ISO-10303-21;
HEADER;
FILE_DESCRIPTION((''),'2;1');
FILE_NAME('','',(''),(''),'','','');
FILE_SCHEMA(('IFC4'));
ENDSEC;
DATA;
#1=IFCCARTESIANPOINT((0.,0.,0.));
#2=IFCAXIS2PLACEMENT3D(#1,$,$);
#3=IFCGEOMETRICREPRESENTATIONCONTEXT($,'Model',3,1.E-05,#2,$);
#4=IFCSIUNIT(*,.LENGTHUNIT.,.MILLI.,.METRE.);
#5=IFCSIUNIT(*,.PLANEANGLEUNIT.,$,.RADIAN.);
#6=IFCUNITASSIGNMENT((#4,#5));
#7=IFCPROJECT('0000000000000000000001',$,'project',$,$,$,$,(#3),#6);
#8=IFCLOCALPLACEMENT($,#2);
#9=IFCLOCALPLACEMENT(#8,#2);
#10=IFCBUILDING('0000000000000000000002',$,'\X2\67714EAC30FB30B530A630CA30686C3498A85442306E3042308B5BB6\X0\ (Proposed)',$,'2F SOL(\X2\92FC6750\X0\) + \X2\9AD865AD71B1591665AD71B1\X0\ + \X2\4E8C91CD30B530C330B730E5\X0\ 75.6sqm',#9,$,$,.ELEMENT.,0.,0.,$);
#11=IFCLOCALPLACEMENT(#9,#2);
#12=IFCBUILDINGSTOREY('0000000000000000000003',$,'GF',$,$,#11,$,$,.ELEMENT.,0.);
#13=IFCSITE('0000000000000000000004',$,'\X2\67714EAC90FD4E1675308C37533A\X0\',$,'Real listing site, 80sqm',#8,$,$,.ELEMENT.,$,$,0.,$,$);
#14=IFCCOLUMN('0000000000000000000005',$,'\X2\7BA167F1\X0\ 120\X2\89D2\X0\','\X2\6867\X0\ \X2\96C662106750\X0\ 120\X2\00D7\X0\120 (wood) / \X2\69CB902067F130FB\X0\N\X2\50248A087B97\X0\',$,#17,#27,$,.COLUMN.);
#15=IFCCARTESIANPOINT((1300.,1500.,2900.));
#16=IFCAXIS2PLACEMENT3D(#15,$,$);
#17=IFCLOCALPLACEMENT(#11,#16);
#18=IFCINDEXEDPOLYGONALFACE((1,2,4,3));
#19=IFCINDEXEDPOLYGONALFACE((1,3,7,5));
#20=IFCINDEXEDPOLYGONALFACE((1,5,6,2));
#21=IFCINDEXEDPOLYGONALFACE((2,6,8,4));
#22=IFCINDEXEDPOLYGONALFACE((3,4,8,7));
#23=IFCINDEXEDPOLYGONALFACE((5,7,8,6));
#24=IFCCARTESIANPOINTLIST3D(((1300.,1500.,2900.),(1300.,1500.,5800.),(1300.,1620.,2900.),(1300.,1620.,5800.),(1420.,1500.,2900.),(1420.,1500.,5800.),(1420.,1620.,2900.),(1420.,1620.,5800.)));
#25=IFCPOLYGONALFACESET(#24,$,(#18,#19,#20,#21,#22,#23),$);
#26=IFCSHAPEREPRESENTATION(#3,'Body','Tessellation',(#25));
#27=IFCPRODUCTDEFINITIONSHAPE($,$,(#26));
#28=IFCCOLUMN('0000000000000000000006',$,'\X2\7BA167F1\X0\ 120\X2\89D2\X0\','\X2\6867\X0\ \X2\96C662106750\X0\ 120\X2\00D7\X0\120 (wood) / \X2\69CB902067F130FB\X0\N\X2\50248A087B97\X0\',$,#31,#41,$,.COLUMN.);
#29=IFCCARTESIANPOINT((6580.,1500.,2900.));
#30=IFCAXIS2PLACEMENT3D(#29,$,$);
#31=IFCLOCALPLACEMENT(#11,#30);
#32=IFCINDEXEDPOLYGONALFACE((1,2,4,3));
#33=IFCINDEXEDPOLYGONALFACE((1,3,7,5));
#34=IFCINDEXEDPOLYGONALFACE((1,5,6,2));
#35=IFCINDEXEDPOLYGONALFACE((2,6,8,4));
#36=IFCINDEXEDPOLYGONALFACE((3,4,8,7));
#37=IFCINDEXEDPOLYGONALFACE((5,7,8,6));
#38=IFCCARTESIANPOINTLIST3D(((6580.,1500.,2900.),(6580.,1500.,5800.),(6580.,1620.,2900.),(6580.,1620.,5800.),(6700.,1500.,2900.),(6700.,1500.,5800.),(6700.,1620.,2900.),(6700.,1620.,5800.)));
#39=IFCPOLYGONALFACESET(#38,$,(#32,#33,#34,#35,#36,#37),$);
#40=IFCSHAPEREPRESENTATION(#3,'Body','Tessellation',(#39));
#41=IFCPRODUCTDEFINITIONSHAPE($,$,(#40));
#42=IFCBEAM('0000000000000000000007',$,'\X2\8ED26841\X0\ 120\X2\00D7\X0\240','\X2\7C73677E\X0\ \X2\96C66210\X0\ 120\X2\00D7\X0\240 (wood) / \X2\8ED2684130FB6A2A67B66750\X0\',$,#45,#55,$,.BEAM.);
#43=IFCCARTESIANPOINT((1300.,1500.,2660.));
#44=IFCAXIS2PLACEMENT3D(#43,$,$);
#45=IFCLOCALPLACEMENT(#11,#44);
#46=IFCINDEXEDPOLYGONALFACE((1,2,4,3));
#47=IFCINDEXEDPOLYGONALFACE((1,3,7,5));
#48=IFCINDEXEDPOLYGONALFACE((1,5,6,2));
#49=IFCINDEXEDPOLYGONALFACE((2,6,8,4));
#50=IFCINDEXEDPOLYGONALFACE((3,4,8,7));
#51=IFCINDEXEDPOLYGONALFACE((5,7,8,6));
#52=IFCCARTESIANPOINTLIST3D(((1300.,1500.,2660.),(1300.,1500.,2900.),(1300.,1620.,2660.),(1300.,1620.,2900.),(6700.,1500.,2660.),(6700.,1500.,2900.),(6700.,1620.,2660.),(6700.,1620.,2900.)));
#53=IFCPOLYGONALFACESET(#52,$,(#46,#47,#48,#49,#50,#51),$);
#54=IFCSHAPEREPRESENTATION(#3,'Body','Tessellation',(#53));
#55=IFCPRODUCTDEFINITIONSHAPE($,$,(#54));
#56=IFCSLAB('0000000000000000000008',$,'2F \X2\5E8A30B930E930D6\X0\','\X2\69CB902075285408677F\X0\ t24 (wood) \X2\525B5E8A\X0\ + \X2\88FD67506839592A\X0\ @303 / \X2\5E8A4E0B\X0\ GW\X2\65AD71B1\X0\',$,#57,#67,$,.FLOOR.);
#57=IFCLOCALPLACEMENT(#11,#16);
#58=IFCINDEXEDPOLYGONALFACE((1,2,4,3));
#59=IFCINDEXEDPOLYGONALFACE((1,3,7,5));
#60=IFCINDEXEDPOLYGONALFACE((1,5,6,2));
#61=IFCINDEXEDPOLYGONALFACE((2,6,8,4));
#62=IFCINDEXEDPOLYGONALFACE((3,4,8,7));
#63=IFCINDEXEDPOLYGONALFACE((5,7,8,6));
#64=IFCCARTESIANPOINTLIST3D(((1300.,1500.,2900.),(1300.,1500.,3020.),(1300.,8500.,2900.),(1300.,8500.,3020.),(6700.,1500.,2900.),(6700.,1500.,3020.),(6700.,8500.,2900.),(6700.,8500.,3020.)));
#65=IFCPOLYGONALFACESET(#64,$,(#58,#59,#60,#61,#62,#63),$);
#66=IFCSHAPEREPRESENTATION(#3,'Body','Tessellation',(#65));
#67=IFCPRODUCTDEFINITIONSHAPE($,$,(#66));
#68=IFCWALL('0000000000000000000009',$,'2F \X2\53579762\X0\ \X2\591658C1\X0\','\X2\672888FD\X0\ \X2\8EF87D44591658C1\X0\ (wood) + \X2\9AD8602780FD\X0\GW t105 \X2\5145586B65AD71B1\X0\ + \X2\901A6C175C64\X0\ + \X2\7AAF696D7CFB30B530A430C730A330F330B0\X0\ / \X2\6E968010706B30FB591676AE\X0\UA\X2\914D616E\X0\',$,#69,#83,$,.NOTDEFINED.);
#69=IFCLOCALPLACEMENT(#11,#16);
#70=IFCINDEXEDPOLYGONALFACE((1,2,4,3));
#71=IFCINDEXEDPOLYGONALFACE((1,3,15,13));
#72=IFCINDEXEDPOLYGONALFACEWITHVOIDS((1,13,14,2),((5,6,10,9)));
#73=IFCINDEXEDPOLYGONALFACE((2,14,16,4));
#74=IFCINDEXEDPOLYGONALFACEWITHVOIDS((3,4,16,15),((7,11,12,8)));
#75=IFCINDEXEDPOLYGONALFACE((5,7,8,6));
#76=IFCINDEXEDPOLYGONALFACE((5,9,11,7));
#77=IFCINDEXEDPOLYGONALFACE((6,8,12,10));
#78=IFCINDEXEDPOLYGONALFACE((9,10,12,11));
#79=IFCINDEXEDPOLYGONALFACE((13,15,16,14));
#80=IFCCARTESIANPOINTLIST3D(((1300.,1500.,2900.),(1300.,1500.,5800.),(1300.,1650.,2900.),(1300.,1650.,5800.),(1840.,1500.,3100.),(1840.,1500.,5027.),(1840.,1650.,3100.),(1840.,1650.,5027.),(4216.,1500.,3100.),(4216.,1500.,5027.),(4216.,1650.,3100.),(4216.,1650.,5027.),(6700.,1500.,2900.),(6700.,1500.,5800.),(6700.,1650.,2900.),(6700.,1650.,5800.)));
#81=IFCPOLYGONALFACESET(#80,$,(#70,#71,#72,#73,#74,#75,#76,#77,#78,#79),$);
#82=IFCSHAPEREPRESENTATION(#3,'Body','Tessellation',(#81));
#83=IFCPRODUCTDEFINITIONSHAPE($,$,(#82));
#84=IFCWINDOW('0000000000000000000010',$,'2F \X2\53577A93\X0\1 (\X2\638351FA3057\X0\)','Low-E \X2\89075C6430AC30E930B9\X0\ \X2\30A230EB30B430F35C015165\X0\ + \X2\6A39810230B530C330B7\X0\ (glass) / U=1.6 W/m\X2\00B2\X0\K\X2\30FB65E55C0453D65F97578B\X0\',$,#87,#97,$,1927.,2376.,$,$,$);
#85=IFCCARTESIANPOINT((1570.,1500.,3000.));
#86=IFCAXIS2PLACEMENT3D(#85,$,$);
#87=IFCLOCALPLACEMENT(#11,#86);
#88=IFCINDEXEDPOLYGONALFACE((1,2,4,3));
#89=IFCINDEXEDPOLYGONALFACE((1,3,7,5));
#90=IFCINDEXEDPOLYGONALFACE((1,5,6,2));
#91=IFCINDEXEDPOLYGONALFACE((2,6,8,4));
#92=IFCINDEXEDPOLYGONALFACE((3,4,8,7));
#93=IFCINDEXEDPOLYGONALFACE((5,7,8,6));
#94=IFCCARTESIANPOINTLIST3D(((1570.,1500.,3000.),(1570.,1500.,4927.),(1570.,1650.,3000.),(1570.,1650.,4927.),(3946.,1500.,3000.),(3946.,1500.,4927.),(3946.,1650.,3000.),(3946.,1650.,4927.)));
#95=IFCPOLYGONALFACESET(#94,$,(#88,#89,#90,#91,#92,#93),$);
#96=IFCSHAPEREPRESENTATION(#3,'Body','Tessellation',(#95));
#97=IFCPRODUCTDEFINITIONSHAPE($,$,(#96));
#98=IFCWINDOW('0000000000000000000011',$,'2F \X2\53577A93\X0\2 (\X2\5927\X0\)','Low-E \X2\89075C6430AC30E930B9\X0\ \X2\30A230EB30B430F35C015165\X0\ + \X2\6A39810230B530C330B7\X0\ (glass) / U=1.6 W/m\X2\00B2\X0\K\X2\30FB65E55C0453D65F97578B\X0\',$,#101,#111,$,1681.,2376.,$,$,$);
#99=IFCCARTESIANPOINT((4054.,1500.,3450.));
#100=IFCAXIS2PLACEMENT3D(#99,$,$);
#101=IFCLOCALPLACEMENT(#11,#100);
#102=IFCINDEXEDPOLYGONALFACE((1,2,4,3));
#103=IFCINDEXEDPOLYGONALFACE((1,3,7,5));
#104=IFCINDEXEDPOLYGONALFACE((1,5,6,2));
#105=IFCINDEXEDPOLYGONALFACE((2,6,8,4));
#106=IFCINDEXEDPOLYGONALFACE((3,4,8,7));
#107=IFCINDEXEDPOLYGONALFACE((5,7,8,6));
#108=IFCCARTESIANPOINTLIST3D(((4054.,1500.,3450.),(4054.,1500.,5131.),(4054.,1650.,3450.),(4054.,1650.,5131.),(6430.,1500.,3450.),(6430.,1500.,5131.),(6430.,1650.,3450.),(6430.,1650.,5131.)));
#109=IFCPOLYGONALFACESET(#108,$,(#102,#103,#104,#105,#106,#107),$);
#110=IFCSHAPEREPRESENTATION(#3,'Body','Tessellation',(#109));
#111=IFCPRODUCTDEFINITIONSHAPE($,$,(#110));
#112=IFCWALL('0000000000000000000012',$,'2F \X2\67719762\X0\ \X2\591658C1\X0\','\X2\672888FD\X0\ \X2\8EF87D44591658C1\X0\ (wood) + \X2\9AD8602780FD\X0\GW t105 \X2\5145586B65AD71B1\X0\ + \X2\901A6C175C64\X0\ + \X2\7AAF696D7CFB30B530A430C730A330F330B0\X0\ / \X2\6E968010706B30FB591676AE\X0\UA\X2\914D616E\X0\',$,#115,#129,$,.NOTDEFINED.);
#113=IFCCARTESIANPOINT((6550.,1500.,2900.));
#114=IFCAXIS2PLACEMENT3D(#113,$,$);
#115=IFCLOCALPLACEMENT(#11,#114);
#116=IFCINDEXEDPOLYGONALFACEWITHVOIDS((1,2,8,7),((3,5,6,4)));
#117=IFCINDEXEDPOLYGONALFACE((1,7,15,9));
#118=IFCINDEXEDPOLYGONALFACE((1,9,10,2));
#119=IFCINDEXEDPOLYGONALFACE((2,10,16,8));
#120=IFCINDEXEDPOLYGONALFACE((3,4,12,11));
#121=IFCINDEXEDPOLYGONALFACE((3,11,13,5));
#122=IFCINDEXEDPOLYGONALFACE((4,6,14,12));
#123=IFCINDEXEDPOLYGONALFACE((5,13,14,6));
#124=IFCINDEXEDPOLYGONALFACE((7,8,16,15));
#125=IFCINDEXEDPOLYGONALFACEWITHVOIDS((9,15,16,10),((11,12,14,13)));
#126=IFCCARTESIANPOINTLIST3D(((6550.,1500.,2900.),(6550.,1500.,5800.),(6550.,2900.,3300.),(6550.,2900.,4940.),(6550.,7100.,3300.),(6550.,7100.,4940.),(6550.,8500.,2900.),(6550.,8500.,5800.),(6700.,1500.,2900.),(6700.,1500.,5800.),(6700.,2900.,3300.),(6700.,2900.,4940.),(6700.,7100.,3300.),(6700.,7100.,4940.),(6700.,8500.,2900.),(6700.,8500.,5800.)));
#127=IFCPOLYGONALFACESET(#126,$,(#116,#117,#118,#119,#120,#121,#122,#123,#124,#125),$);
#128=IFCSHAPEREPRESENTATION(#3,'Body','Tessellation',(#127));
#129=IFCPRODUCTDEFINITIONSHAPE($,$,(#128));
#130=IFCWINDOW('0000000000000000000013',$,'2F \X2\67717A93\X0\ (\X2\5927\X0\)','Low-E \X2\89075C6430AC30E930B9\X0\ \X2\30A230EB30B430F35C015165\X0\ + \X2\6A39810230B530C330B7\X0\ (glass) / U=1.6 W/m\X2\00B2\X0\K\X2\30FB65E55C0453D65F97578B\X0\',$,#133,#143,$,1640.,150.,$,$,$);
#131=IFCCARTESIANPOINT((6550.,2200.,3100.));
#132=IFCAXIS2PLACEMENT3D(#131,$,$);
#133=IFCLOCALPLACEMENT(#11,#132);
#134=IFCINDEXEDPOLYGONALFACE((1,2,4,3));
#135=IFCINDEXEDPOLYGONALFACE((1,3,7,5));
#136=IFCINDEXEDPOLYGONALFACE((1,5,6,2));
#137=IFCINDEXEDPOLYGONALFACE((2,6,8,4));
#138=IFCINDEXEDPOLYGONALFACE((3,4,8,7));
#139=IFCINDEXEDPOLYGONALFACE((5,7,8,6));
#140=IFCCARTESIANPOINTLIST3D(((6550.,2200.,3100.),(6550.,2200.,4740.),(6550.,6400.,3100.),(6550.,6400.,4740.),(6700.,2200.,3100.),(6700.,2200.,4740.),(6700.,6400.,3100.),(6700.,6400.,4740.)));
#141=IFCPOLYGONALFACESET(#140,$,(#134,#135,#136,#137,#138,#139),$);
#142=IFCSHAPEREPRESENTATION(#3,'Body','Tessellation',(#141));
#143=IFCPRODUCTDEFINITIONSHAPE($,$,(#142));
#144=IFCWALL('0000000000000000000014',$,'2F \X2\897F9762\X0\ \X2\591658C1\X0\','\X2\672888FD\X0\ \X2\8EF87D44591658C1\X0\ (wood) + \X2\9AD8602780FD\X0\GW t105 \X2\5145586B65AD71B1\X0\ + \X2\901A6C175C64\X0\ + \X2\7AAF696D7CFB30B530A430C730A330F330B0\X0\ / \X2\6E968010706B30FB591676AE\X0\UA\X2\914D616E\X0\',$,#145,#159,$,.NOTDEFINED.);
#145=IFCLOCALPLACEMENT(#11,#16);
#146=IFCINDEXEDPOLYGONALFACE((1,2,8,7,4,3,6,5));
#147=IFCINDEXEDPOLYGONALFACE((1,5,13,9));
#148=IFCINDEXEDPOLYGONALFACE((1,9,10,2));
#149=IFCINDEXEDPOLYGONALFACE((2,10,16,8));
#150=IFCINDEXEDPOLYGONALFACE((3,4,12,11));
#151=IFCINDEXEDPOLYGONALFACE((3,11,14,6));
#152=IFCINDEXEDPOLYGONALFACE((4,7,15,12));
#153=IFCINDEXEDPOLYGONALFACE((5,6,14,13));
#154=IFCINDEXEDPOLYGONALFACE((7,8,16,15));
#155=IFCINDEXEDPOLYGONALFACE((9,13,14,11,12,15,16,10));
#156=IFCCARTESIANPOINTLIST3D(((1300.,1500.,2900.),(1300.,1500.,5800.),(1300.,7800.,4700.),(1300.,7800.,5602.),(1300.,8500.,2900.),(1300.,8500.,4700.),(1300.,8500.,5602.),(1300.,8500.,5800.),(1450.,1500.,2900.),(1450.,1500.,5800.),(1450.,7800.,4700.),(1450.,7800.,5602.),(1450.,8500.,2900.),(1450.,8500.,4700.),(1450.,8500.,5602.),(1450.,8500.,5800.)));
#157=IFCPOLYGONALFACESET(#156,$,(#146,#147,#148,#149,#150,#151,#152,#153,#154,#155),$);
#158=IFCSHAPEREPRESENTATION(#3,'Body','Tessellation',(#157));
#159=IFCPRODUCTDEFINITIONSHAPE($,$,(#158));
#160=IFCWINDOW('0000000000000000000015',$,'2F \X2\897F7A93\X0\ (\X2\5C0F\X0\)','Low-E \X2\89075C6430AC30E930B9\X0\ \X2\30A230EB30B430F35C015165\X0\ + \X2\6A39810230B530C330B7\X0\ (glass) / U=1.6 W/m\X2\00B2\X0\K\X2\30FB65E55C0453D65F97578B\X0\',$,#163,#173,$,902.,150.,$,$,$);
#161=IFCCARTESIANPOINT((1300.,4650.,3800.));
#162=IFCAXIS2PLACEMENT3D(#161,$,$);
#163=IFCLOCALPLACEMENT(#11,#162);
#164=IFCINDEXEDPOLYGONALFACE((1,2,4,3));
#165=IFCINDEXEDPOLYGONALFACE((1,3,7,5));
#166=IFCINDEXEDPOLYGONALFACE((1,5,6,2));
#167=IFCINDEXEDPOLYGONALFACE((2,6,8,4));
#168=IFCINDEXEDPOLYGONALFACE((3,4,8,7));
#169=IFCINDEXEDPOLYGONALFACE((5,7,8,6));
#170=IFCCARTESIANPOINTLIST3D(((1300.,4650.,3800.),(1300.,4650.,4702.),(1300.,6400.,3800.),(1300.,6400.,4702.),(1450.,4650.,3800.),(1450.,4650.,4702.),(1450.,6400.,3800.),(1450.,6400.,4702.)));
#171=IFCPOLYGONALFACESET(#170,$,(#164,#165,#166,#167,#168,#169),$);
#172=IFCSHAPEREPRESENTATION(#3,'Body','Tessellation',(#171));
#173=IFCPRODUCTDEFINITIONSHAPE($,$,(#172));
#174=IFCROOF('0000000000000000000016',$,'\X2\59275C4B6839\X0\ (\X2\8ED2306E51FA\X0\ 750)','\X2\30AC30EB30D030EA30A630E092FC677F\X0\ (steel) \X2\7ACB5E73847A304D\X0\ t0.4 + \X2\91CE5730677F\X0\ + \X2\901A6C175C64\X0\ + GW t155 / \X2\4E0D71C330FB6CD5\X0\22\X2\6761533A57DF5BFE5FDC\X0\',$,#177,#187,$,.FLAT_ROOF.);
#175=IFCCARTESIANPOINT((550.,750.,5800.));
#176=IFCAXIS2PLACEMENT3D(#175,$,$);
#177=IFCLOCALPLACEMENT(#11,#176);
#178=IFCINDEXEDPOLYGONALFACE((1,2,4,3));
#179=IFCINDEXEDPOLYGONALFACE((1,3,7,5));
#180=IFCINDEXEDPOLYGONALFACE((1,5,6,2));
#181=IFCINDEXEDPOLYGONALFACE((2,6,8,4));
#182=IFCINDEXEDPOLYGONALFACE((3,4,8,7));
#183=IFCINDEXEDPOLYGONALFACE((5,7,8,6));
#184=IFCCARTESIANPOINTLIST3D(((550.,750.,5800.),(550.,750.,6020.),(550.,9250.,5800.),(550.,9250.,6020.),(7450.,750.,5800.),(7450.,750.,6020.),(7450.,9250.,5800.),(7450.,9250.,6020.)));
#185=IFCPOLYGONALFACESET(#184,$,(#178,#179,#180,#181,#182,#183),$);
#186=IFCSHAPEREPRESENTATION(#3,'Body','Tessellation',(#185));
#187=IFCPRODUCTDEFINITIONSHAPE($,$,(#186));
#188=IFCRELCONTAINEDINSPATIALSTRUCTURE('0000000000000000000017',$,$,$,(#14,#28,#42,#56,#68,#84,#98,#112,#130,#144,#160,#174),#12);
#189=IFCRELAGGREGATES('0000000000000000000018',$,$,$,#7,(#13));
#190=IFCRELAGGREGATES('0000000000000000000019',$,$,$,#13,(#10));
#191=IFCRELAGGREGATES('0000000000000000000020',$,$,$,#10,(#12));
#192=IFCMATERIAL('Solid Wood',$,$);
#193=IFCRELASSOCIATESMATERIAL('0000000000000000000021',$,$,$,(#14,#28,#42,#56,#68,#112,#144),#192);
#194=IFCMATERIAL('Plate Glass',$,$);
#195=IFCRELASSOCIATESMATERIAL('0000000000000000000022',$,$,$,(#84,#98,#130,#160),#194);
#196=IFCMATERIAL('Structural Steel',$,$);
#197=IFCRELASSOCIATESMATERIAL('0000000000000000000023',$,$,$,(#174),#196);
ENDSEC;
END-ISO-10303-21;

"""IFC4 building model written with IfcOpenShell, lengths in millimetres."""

from ifc_helpers import new_model, si_unit, frame, frame_2d, origin, place, context, project, spatial, rectangle, extrude, material, element, fill, save


model = new_model("IFC4")

# Units and contexts
model_context = context("Model", 3, precision=1e-05, world=origin())
ifc_project = project(units=[si_unit("LENGTHUNIT", "METRE", prefix="MILLI"), si_unit("PLANEANGLEUNIT", "RADIAN")], contexts=[model_context])

# Site, building, storey
site_placement = place(None, origin())
site = spatial("IfcSite", under=ifc_project, at=site_placement, Name="東京都世田谷区", ObjectType="Real listing site, 80sqm", CompositionType="ELEMENT", RefElevation=0.0)
building_placement = place(site_placement, origin())
building = spatial("IfcBuilding", under=site, at=building_placement, Name="東京・サウナと水風呂のある家 (Proposed)", ObjectType="2F SOL(鋼材) + 高断熱外断熱 + 二重サッシュ 75.6sqm", CompositionType="ELEMENT", ElevationOfRefHeight=0.0, ElevationOfTerrain=0.0)
storey_placement = place(building_placement, origin())
storey = spatial("IfcBuildingStorey", under=building, at=storey_placement, Name="GF", CompositionType="ELEMENT", Elevation=0.0)

# Columns
ifc_material_1 = material(Name="Solid Wood")
column_1_placement = place(storey_placement, frame((1300.0, 1500.0, 2900.0)))
element("IfcColumn", 1, at=column_1_placement, inside=storey, material=ifc_material_1, Name="管柱 120角", Description="桧 集成材 120×120 (wood) / 構造柱・N値計算", PredefinedType="COLUMN", context=model_context, shape_type="SweptSolid", body=[
    extrude(rectangle(XDim=120.0, YDim=120.0, at=frame_2d((60.0, 60.0))), frame((1300.0, 1500.0, 2900.0)), (0.0, 0.0, 1.0), 2900.0),
])
column_2_placement = place(storey_placement, frame((6580.0, 1500.0, 2900.0)))
element("IfcColumn", 2, at=column_2_placement, inside=storey, material=ifc_material_1, Name="管柱 120角", Description="桧 集成材 120×120 (wood) / 構造柱・N値計算", PredefinedType="COLUMN", context=model_context, shape_type="SweptSolid", body=[
    extrude(rectangle(XDim=120.0, YDim=120.0, at=frame_2d((60.0, 60.0))), frame((6580.0, 1500.0, 2900.0)), (0.0, 0.0, 1.0), 2900.0),
])

# Beam
beam_1_placement = place(storey_placement, frame((1300.0, 1500.0, 2660.0)))
element("IfcBeam", 3, at=beam_1_placement, inside=storey, material=ifc_material_1, Name="軒桁 120×240", Description="米松 集成 120×240 (wood) / 軒桁・横架材", PredefinedType="BEAM", context=model_context, shape_type="SweptSolid", body=[
    extrude(rectangle(XDim=5400.0, YDim=120.0, at=frame_2d((2700.0, 60.0))), frame((1300.0, 1500.0, 2660.0)), (0.0, 0.0, 1.0), 240.0),
])

# Slab
slab_placement = place(storey_placement, frame((1300.0, 1500.0, 2900.0)))
element("IfcSlab", 4, at=slab_placement, inside=storey, material=ifc_material_1, Name="2F 床スラブ", Description="構造用合板 t24 (wood) 剛床 + 製材根太 @303 / 床下 GW断熱", PredefinedType="FLOOR", context=model_context, shape_type="SweptSolid", body=[
    extrude(rectangle(XDim=5400.0, YDim=7000.0, at=frame_2d((2700.0, 3500.0))), frame((1300.0, 1500.0, 2900.0)), (0.0, 0.0, 1.0), 120.0),
])

# Wall, openings, windows
wall_1_placement = place(storey_placement, frame((1300.0, 1500.0, 2900.0)))
wall_1 = element("IfcWall", 5, at=wall_1_placement, inside=storey, material=ifc_material_1, Name="2F 南面 外壁", Description="木製 軸組外壁 (wood) + 高性能GW t105 充填断熱 + 通気層 + 窯業系サイディング / 準耐火・外皮UA配慮", PredefinedType="NOTDEFINED", context=model_context, shape_type="SweptSolid", body=[
    extrude(rectangle(XDim=5400.0, YDim=150.0, at=frame_2d((2700.0, 75.0))), frame((1300.0, 1500.0, 2900.0)), (0.0, 0.0, 1.0), 2900.0),
])
opening_1_placement = place(storey_placement, frame((1570.0, 1500.0, 3000.0)))
opening_1 = element("IfcOpeningElement", 6, at=opening_1_placement, cuts=wall_1, PredefinedType="NOTDEFINED", context=model_context, shape_type="SweptSolid", body=[
    extrude(rectangle(XDim=2376.0, YDim=150.0, at=frame_2d((1188.0, 75.0))), frame((1570.0, 1500.0, 3000.0)), (0.0, 0.0, 1.0), 1927.0),
])
opening_2_placement = place(storey_placement, frame((4054.0, 1500.0, 3450.0)))
opening_2 = element("IfcOpeningElement", 7, at=opening_2_placement, cuts=wall_1, PredefinedType="NOTDEFINED", context=model_context, shape_type="SweptSolid", body=[
    extrude(rectangle(XDim=2376.0, YDim=150.0, at=frame_2d((1188.0, 75.0))), frame((4054.0, 1500.0, 3450.0)), (0.0, 0.0, 1.0), 1681.0),
])
ifc_material_2 = material(Name="Plate Glass")
window_1_placement = place(storey_placement, frame((1570.0, 1500.0, 3000.0)))
window_1 = element("IfcWindow", 8, at=window_1_placement, inside=storey, material=ifc_material_2, Name="2F 南窓1 (掃出し)", Description="Low-E 複層ガラス アルゴン封入 + 樹脂サッシ (glass) / U=1.6 W/m²K・日射取得型", OverallHeight=1927.0, OverallWidth=2376.0, context=model_context, shape_type="SweptSolid", body=[
    extrude(rectangle(XDim=2376.0, YDim=150.0, at=frame_2d((1188.0, 75.0))), frame((1570.0, 1500.0, 3000.0)), (0.0, 0.0, 1.0), 1927.0),
])
fill(opening_1, window_1)
window_2_placement = place(storey_placement, frame((4054.0, 1500.0, 3450.0)))
window_2 = element("IfcWindow", 9, at=window_2_placement, inside=storey, material=ifc_material_2, Name="2F 南窓2 (大)", Description="Low-E 複層ガラス アルゴン封入 + 樹脂サッシ (glass) / U=1.6 W/m²K・日射取得型", OverallHeight=1681.0, OverallWidth=2376.0, context=model_context, shape_type="SweptSolid", body=[
    extrude(rectangle(XDim=2376.0, YDim=150.0, at=frame_2d((1188.0, 75.0))), frame((4054.0, 1500.0, 3450.0)), (0.0, 0.0, 1.0), 1681.0),
])
fill(opening_2, window_2)

# Walls, openings, windows
wall_2_placement = place(storey_placement, frame((6550.0, 1500.0, 2900.0)))
wall_2 = element("IfcWall", 10, at=wall_2_placement, inside=storey, material=ifc_material_1, Name="2F 東面 外壁", Description="木製 軸組外壁 (wood) + 高性能GW t105 充填断熱 + 通気層 + 窯業系サイディング / 準耐火・外皮UA配慮", PredefinedType="NOTDEFINED", context=model_context, shape_type="SweptSolid", body=[
    extrude(rectangle(XDim=150.0, YDim=7000.0, at=frame_2d((75.0, 3500.0))), frame((6550.0, 1500.0, 2900.0)), (0.0, 0.0, 1.0), 2900.0),
])
opening_3_placement = place(storey_placement, frame((6550.0, 2200.0, 3100.0)))
opening_3 = element("IfcOpeningElement", 11, at=opening_3_placement, cuts=wall_2, PredefinedType="NOTDEFINED", context=model_context, shape_type="SweptSolid", body=[
    extrude(rectangle(XDim=150.0, YDim=4200.0, at=frame_2d((75.0, 2100.0))), frame((6550.0, 2200.0, 3100.0)), (0.0, 0.0, 1.0), 1640.0),
])
window_3_placement = place(storey_placement, frame((6550.0, 2200.0, 3100.0)))
window_3 = element("IfcWindow", 12, at=window_3_placement, inside=storey, material=ifc_material_2, Name="2F 東窓 (大)", Description="Low-E 複層ガラス アルゴン封入 + 樹脂サッシ (glass) / U=1.6 W/m²K・日射取得型", OverallHeight=1640.0, OverallWidth=150.0, context=model_context, shape_type="SweptSolid", body=[
    extrude(rectangle(XDim=150.0, YDim=4200.0, at=frame_2d((75.0, 2100.0))), frame((6550.0, 2200.0, 3100.0)), (0.0, 0.0, 1.0), 1640.0),
])
fill(opening_3, window_3)
wall_3_placement = place(storey_placement, frame((1300.0, 1500.0, 2900.0)))
wall_3 = element("IfcWall", 13, at=wall_3_placement, inside=storey, material=ifc_material_1, Name="2F 西面 外壁", Description="木製 軸組外壁 (wood) + 高性能GW t105 充填断熱 + 通気層 + 窯業系サイディング / 準耐火・外皮UA配慮", PredefinedType="NOTDEFINED", context=model_context, shape_type="SweptSolid", body=[
    extrude(rectangle(XDim=150.0, YDim=7000.0, at=frame_2d((75.0, 3500.0))), frame((1300.0, 1500.0, 2900.0)), (0.0, 0.0, 1.0), 2900.0),
])
opening_4_placement = place(storey_placement, frame((1300.0, 4650.0, 3800.0)))
opening_4 = element("IfcOpeningElement", 14, at=opening_4_placement, cuts=wall_3, PredefinedType="NOTDEFINED", context=model_context, shape_type="SweptSolid", body=[
    extrude(rectangle(XDim=150.0, YDim=1750.0, at=frame_2d((75.0, 875.0))), frame((1300.0, 4650.0, 3800.0)), (0.0, 0.0, 1.0), 902.0),
])
window_4_placement = place(storey_placement, frame((1300.0, 4650.0, 3800.0)))
window_4 = element("IfcWindow", 15, at=window_4_placement, inside=storey, material=ifc_material_2, Name="2F 西窓 (小)", Description="Low-E 複層ガラス アルゴン封入 + 樹脂サッシ (glass) / U=1.6 W/m²K・日射取得型", OverallHeight=902.0, OverallWidth=150.0, context=model_context, shape_type="SweptSolid", body=[
    extrude(rectangle(XDim=150.0, YDim=1750.0, at=frame_2d((75.0, 875.0))), frame((1300.0, 4650.0, 3800.0)), (0.0, 0.0, 1.0), 902.0),
])
fill(opening_4, window_4)

# Roof
ifc_material_3 = material(Name="Structural Steel")
roof_placement = place(storey_placement, frame((550.0, 750.0, 5800.0)))
element("IfcRoof", 16, at=roof_placement, inside=storey, material=ifc_material_3, Name="大屋根 (軒の出 750)", Description="ガルバリウム鋼板 (steel) 立平葺き t0.4 + 野地板 + 通気層 + GW t155 / 不燃・法22条区域対応", PredefinedType="FLAT_ROOF", context=model_context, shape_type="SweptSolid", body=[
    extrude(rectangle(XDim=6900.0, YDim=8500.0, at=frame_2d((3450.0, 4250.0))), frame((550.0, 750.0, 5800.0)), (0.0, 0.0, 1.0), 220.0),
])

save(model, "model.ifc")
